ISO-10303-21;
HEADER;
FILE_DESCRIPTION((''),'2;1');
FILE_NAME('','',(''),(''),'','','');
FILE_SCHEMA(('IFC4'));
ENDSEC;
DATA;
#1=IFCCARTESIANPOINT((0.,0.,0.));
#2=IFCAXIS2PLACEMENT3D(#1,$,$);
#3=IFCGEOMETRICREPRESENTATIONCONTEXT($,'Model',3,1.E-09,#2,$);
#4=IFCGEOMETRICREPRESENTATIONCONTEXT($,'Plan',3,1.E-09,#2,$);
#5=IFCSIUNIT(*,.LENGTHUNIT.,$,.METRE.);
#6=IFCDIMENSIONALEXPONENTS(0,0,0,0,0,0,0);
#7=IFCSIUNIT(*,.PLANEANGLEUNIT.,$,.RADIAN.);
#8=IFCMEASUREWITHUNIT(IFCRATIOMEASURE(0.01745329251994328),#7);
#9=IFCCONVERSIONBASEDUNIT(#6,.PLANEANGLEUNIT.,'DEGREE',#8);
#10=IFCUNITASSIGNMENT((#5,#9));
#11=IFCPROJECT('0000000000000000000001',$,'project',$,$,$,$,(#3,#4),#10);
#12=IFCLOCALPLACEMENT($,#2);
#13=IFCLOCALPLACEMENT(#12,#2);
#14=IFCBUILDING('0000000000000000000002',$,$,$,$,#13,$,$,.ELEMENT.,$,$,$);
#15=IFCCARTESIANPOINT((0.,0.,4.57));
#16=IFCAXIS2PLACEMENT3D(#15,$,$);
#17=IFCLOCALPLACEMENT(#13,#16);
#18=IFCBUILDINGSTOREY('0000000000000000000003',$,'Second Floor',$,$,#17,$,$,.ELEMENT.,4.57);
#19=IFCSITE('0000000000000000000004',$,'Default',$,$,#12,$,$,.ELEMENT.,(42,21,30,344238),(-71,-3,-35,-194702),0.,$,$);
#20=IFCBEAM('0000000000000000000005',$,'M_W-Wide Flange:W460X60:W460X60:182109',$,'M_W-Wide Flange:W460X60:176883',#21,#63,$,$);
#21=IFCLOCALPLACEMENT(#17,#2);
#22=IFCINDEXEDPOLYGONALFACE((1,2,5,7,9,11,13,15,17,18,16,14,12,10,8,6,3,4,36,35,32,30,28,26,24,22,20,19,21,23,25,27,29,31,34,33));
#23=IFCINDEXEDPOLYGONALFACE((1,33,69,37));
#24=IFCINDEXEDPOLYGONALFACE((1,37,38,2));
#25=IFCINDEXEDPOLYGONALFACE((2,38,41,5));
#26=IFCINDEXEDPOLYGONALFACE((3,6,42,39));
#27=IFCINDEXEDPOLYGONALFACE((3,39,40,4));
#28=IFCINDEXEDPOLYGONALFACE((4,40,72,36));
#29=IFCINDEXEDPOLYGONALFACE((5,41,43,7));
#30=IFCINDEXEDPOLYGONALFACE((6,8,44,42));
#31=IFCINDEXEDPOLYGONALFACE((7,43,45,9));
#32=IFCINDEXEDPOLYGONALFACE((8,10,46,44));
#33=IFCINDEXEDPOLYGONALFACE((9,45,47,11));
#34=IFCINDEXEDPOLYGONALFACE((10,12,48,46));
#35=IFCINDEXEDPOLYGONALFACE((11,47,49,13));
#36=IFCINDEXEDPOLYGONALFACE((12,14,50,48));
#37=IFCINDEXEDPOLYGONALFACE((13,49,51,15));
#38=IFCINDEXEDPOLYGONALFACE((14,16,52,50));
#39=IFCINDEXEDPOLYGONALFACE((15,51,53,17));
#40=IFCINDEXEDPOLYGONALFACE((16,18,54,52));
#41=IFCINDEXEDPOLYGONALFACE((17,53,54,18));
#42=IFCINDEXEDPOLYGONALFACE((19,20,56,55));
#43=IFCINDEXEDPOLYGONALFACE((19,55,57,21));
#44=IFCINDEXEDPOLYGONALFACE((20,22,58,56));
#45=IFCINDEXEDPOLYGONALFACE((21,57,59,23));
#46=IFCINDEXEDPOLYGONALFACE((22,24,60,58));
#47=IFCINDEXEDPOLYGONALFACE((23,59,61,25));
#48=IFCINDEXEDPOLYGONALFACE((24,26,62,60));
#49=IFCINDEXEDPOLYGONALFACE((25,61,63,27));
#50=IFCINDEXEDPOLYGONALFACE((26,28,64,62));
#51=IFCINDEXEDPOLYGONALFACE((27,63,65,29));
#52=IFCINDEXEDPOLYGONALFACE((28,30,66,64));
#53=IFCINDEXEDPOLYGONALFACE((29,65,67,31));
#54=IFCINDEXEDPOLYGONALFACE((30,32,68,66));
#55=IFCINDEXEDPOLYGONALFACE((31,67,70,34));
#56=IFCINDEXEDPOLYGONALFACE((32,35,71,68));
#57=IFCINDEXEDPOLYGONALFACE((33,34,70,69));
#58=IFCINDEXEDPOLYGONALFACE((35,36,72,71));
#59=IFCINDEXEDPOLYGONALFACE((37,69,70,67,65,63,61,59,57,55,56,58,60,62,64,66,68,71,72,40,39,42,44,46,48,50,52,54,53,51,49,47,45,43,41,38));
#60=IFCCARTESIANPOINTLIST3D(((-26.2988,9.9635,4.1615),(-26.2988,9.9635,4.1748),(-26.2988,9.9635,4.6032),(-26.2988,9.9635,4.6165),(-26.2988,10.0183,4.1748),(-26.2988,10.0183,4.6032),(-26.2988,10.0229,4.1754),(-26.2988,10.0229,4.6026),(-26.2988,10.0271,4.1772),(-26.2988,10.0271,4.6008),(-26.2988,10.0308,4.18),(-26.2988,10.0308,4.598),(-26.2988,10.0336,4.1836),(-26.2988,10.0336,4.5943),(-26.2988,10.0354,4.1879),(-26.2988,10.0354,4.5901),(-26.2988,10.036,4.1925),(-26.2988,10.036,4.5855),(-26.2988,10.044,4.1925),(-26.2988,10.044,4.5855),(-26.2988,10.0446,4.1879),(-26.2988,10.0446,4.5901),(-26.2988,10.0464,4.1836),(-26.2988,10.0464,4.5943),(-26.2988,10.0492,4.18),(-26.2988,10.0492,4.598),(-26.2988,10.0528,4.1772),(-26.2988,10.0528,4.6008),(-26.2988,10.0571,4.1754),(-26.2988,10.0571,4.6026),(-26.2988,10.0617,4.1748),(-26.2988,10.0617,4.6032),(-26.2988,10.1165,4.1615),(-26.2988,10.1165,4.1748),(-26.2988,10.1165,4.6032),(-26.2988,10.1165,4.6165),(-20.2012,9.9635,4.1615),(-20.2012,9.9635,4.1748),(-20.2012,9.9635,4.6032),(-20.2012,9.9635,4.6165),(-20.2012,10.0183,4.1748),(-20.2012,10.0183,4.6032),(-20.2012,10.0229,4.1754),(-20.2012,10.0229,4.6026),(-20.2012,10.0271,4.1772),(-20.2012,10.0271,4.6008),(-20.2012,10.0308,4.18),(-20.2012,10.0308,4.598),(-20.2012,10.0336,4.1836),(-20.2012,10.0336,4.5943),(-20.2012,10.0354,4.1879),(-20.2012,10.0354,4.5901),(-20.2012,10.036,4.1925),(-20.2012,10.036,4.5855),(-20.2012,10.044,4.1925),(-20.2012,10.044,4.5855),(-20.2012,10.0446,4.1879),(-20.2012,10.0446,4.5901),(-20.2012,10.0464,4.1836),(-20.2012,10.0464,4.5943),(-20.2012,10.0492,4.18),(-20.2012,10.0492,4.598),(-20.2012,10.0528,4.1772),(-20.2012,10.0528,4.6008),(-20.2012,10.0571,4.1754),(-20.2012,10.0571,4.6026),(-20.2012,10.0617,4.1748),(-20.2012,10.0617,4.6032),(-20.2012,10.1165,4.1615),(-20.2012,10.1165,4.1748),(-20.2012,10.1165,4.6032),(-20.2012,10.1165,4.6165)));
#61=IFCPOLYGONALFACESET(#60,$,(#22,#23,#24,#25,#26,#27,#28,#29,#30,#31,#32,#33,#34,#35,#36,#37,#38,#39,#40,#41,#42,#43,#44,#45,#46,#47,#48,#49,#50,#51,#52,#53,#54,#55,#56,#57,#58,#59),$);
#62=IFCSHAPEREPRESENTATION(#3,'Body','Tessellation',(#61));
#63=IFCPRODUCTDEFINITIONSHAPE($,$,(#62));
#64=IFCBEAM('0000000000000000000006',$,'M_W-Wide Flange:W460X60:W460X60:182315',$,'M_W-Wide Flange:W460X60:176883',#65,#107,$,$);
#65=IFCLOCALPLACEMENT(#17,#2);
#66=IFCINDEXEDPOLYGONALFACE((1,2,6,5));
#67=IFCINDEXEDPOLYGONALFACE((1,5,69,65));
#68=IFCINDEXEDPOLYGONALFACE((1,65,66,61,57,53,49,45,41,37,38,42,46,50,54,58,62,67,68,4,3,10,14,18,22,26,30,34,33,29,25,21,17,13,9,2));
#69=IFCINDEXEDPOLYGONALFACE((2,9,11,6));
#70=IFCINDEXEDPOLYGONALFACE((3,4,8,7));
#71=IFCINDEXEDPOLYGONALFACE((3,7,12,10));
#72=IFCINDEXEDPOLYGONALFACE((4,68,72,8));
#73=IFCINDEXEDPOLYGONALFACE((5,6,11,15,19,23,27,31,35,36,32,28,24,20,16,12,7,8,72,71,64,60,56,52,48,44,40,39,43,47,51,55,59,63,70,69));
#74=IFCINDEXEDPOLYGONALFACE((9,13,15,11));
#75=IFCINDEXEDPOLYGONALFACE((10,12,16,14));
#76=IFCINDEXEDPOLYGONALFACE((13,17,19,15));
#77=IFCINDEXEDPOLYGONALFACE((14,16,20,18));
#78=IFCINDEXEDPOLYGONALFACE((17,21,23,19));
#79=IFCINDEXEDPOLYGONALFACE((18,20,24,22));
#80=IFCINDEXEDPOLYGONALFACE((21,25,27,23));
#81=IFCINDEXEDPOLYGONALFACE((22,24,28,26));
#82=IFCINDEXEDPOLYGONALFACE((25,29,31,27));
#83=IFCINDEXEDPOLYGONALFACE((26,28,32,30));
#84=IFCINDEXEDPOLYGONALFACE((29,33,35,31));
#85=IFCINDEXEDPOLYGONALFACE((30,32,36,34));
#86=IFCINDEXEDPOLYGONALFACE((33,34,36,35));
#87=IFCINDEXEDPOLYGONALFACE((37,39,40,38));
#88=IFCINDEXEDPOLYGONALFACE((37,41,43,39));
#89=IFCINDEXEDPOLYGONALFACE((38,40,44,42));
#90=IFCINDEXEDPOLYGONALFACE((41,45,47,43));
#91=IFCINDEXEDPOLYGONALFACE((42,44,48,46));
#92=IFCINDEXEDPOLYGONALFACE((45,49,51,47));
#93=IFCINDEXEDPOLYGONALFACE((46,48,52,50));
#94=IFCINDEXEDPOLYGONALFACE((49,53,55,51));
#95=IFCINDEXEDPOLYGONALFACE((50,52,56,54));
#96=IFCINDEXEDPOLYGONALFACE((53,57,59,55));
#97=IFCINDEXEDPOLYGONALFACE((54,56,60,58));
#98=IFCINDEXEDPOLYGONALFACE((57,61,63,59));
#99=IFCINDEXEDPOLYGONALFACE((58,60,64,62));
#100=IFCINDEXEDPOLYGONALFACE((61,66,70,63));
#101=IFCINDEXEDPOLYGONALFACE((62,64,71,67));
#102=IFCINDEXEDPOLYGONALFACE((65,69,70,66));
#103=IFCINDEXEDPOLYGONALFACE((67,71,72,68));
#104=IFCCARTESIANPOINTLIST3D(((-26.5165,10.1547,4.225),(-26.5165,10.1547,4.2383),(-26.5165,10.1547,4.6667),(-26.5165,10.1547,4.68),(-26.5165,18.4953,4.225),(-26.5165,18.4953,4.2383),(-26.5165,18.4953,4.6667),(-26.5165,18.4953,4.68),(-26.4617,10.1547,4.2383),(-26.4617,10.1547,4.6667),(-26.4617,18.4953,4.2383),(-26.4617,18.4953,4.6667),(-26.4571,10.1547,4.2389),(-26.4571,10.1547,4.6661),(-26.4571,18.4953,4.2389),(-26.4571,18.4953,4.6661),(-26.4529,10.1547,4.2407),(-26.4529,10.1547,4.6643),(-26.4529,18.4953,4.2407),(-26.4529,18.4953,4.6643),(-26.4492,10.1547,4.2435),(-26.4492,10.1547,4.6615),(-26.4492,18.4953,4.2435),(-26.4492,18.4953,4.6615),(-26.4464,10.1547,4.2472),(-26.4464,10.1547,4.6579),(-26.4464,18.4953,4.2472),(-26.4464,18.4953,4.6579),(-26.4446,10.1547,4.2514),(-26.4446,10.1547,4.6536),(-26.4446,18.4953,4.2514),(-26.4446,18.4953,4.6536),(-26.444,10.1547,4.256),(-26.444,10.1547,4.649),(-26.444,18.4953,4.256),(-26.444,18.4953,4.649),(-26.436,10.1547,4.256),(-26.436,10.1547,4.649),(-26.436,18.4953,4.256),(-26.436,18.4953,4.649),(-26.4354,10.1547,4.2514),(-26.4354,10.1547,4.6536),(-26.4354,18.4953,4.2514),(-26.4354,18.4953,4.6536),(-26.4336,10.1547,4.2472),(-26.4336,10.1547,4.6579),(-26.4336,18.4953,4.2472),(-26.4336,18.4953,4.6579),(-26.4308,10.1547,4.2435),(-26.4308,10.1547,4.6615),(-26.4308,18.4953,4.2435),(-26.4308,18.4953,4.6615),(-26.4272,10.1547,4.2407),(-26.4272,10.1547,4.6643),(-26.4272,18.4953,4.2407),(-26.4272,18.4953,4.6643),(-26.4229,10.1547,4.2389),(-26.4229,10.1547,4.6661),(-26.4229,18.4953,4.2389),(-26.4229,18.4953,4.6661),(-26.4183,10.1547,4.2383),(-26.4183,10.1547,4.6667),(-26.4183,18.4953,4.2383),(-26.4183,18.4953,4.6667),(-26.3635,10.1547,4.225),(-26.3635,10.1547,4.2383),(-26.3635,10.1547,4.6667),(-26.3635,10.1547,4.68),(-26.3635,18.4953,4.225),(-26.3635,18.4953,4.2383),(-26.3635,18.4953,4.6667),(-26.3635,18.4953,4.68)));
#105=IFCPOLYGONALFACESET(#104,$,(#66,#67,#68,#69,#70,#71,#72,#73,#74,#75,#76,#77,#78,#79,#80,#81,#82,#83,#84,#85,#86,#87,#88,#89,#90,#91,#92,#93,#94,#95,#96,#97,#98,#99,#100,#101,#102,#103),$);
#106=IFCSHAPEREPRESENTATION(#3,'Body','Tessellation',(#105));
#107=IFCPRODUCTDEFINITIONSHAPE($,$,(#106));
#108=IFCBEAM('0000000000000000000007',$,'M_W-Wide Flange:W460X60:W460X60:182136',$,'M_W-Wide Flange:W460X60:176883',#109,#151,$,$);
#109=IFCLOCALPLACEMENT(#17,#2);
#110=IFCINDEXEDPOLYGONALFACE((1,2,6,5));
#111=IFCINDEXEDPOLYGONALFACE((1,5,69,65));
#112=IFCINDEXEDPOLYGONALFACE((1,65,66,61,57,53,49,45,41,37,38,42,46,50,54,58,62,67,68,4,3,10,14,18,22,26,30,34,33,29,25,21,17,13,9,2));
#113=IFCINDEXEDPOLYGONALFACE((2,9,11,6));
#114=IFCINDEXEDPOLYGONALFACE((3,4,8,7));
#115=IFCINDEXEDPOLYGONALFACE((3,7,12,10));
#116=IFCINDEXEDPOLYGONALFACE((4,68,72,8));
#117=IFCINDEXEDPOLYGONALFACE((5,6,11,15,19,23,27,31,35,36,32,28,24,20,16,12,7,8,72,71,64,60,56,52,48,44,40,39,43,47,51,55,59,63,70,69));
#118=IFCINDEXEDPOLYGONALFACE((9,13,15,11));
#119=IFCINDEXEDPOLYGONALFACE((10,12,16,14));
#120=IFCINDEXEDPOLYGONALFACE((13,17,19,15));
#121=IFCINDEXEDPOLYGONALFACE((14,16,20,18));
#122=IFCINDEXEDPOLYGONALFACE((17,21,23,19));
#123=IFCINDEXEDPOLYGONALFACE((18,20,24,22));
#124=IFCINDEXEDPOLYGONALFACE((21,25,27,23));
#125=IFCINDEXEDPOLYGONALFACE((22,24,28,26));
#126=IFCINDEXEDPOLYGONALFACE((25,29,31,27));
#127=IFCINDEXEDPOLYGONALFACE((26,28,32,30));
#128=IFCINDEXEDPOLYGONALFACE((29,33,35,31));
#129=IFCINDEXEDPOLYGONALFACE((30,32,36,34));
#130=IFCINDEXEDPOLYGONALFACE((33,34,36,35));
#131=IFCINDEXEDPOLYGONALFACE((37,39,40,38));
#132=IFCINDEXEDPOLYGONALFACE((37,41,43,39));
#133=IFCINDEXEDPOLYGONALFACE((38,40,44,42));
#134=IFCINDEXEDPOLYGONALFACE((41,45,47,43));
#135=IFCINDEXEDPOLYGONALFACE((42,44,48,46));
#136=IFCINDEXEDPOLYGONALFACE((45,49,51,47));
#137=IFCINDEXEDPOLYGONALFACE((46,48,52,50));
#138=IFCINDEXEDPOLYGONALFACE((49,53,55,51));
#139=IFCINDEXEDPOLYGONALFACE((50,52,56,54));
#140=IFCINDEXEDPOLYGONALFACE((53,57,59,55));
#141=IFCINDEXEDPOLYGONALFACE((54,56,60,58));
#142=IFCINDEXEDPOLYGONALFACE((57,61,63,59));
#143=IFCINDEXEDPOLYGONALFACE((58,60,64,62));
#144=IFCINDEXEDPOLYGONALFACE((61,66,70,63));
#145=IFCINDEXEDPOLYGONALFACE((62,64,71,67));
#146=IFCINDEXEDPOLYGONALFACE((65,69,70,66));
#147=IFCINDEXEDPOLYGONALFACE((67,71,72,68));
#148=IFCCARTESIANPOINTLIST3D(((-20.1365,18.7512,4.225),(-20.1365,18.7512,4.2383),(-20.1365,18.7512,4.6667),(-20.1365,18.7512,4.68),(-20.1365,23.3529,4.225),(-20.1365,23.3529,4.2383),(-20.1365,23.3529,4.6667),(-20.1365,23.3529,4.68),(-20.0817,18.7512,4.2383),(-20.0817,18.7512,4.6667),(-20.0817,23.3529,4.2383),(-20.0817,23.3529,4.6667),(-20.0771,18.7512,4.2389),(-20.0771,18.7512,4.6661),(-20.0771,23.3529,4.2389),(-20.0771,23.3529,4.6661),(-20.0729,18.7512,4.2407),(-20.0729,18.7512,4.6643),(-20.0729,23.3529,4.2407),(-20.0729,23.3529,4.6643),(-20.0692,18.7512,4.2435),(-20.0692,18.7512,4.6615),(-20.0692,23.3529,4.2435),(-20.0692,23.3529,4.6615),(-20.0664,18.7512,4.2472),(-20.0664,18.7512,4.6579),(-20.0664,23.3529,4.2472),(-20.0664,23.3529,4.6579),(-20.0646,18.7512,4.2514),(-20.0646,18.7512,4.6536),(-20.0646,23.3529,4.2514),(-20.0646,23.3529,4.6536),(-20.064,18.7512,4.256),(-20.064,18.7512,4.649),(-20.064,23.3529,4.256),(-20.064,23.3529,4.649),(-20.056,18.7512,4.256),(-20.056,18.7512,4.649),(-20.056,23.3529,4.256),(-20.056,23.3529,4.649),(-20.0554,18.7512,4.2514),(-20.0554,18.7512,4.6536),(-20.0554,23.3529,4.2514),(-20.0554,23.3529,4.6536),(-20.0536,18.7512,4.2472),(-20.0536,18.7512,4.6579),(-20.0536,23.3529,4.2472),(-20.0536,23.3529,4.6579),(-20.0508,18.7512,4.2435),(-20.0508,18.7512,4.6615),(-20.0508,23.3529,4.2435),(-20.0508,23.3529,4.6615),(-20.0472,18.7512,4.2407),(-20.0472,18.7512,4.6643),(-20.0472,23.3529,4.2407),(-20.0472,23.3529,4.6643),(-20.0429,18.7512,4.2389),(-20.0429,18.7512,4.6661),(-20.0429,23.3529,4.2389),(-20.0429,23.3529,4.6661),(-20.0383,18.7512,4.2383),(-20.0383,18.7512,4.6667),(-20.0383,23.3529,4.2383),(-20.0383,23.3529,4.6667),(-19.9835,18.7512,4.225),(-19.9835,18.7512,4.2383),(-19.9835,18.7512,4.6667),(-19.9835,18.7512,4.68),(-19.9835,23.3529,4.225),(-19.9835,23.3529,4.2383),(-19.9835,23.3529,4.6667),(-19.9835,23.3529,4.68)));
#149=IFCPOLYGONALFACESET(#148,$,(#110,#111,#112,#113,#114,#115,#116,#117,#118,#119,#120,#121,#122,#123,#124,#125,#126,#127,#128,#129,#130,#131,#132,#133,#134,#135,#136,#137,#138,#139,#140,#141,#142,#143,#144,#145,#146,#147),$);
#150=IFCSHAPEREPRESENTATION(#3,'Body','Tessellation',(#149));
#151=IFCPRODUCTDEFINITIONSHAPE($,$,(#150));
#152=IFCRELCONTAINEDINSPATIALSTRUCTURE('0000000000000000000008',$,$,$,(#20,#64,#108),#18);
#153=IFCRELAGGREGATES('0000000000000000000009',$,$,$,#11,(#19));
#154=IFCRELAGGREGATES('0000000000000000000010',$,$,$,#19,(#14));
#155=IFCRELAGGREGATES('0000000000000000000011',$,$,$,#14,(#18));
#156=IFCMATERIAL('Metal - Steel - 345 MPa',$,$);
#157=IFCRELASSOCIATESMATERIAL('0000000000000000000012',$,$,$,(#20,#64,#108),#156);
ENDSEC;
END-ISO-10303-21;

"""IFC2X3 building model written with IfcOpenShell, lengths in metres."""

from ifc_helpers import new_model, entity, si_unit, converted_unit, frame, frame_2d, origin, place, context, project, spatial, polyline, circle_curve, parameter, trimmed, segment, composite_curve, outline, extrude, material, element, save


model = new_model("IFC2X3")

# Units and contexts
model_context = context("Model", 3, precision=1e-09, world=origin())
plan_context = context("Plan", 3, precision=1e-09, world=origin())
ifc_project = project(units=[si_unit("LENGTHUNIT", "METRE"), converted_unit("PLANEANGLEUNIT", "DEGREE", entity("IfcRatioMeasure", 0.01745329251994328), si_unit("PLANEANGLEUNIT", "RADIAN"), dimensions=[0, 0, 0, 0, 0, 0, 0])], contexts=[model_context, plan_context])

# Site, building, storey
site_placement = place(None, origin())
site = spatial("IfcSite", under=ifc_project, at=site_placement, Name="Default", CompositionType="ELEMENT", RefLatitude=(42, 21, 30, 344238), RefLongitude=(-71, -3, -35, -194702), RefElevation=0.0)
building_placement = place(site_placement, origin())
building = spatial("IfcBuilding", under=site, at=building_placement, CompositionType="ELEMENT")
storey_placement = place(building_placement, frame((0.0, 0.0, 4.57)))
storey = spatial("IfcBuildingStorey", under=building, at=storey_placement, Name="Second Floor", CompositionType="ELEMENT", Elevation=4.57)

# Shared definitions
ifc_material = material(Name="Metal - Steel - 345 MPa")

# Beams
beam_1_placement = place(storey_placement, frame((-26.437, 10.04, 4.6165), z_axis=(0.0, 0.0, 1.0), x_axis=(0.0, -1.0, 0.0)))
element("IfcBeam", 1, at=beam_1_placement, inside=storey, material=ifc_material, Name="M_W-Wide Flange:W460X60:W460X60:182109", ObjectType="M_W-Wide Flange:W460X60:176883", context=model_context, shape_type="SweptSolid", body=[
    extrude(outline(composite_curve([segment(polyline([(-0.0765, -0.2142), (-0.0765, -0.2275)]), True, "CONTINUOUS"), segment(polyline([(-0.0765, -0.2275), (0.0765, -0.2275)]), True, "CONTINUOUS"), segment(polyline([(0.0765, -0.2275), (0.0765, -0.2142)]), True, "CONTINUOUS"), segment(polyline([(0.0765, -0.2142), (0.0217, -0.2142)]), True, "CONTINUOUS"), segment(trimmed(circle_curve(frame_2d((0.0217, -0.1965), x_axis=(0.0, -1.0)), 0.0177), [parameter(270.0)], [parameter(360.0)], True, "PARAMETER"), False, "CONTINUOUS"), segment(polyline([(0.004, -0.1965), (0.004, 0.1965)]), True, "CONTINUOUS"), segment(trimmed(circle_curve(frame_2d((0.0217, 0.1965), x_axis=(-1.0, 0.0)), 0.0177), [parameter(270.0)], [parameter(360.0)], True, "PARAMETER"), False, "CONTINUOUS"), segment(polyline([(0.0217, 0.2142), (0.0765, 0.2142)]), True, "CONTINUOUS"), segment(polyline([(0.0765, 0.2142), (0.0765, 0.2275)]), True, "CONTINUOUS"), segment(polyline([(0.0765, 0.2275), (-0.0765, 0.2275)]), True, "CONTINUOUS"), segment(polyline([(-0.0765, 0.2275), (-0.0765, 0.2142)]), True, "CONTINUOUS"), segment(polyline([(-0.0765, 0.2142), (-0.0217, 0.2142)]), True, "CONTINUOUS"), segment(trimmed(circle_curve(frame_2d((-0.0217, 0.1965), x_axis=(0.0, 1.0)), 0.0177), [parameter(270.0)], [parameter(360.0)], True, "PARAMETER"), False, "CONTINUOUS"), segment(polyline([(-0.004, 0.1965), (-0.004, -0.1965)]), True, "CONTINUOUS"), segment(trimmed(circle_curve(frame_2d((-0.0217, -0.1965), x_axis=(1.0, 0.0)), 0.0177), [parameter(270.0)], [parameter(0.0)], True, "PARAMETER"), False, "CONTINUOUS"), segment(polyline([(-0.0217, -0.2142), (-0.0765, -0.2142)]), True, "CONTINUOUS")], self_intersect=False)), frame((0.0, 0.1382, -0.2275), z_axis=(0.0, -1.0, 0.0), x_axis=(1.0, 0.0, 0.0)), (0.0, 0.0, -1.0), 6.0976),
])
beam_2_placement = place(storey_placement, frame((-26.44, 18.6078, 4.68), z_axis=(0.0, 0.0, 1.0), x_axis=(-1.0, 0.0, 0.0)))
element("IfcBeam", 2, at=beam_2_placement, inside=storey, material=ifc_material, Name="M_W-Wide Flange:W460X60:W460X60:182315", ObjectType="M_W-Wide Flange:W460X60:176883", context=model_context, shape_type="SweptSolid", body=[
    extrude(outline(composite_curve([segment(polyline([(0.2142, -0.0765), (0.2275, -0.0765)]), True, "CONTINUOUS"), segment(polyline([(0.2275, -0.0765), (0.2275, 0.0765)]), True, "CONTINUOUS"), segment(polyline([(0.2275, 0.0765), (0.2142, 0.0765)]), True, "CONTINUOUS"), segment(polyline([(0.2142, 0.0765), (0.2142, 0.0217)]), True, "CONTINUOUS"), segment(trimmed(circle_curve(frame_2d((0.1965, 0.0217), x_axis=(1.0, 0.0)), 0.0177), [parameter(270.0)], [parameter(360.0)], True, "PARAMETER"), False, "CONTINUOUS"), segment(polyline([(0.1965, 0.004), (-0.1965, 0.004)]), True, "CONTINUOUS"), segment(trimmed(circle_curve(frame_2d((-0.1965, 0.0217), x_axis=(0.0, -1.0)), 0.0177), [parameter(270.0)], [parameter(360.0)], True, "PARAMETER"), False, "CONTINUOUS"), segment(polyline([(-0.2142, 0.0217), (-0.2142, 0.0765)]), True, "CONTINUOUS"), segment(polyline([(-0.2142, 0.0765), (-0.2275, 0.0765)]), True, "CONTINUOUS"), segment(polyline([(-0.2275, 0.0765), (-0.2275, -0.0765)]), True, "CONTINUOUS"), segment(polyline([(-0.2275, -0.0765), (-0.2142, -0.0765)]), True, "CONTINUOUS"), segment(polyline([(-0.2142, -0.0765), (-0.2142, -0.0217)]), True, "CONTINUOUS"), segment(trimmed(circle_curve(frame_2d((-0.1965, -0.0217), x_axis=(-1.0, 0.0)), 0.0177), [parameter(270.0)], [parameter(360.0)], True, "PARAMETER"), False, "CONTINUOUS"), segment(polyline([(-0.1965, -0.004), (0.1965, -0.004)]), True, "CONTINUOUS"), segment(trimmed(circle_curve(frame_2d((0.1965, -0.0217), x_axis=(0.0, 1.0)), 0.0177), [parameter(270.0)], [parameter(0.0)], True, "PARAMETER"), False, "CONTINUOUS"), segment(polyline([(0.2142, -0.0217), (0.2142, -0.0765)]), True, "CONTINUOUS")], self_intersect=False)), frame((0.0, 8.4531, -0.2275), z_axis=(0.0, -1.0, 0.0), x_axis=(0.0, 0.0, -1.0)), (0.0, 0.0, 1.0), 8.3406),
])
beam_3_placement = place(storey_placement, frame((-20.06, 18.6139, 4.68)))
element("IfcBeam", 3, at=beam_3_placement, inside=storey, material=ifc_material, Name="M_W-Wide Flange:W460X60:W460X60:182136", ObjectType="M_W-Wide Flange:W460X60:176883", context=model_context, shape_type="SweptSolid", body=[
    extrude(outline(composite_curve([segment(polyline([(-0.0765, -0.2142), (-0.0765, -0.2275)]), True, "CONTINUOUS"), segment(polyline([(-0.0765, -0.2275), (0.0765, -0.2275)]), True, "CONTINUOUS"), segment(polyline([(0.0765, -0.2275), (0.0765, -0.2142)]), True, "CONTINUOUS"), segment(polyline([(0.0765, -0.2142), (0.0217, -0.2142)]), True, "CONTINUOUS"), segment(trimmed(circle_curve(frame_2d((0.0217, -0.1965), x_axis=(0.0, -1.0)), 0.0177), [parameter(270.0)], [parameter(360.0)], True, "PARAMETER"), False, "CONTINUOUS"), segment(polyline([(0.004, -0.1965), (0.004, 0.1965)]), True, "CONTINUOUS"), segment(trimmed(circle_curve(frame_2d((0.0217, 0.1965), x_axis=(-1.0, 0.0)), 0.0177), [parameter(270.0)], [parameter(360.0)], True, "PARAMETER"), False, "CONTINUOUS"), segment(polyline([(0.0217, 0.2142), (0.0765, 0.2142)]), True, "CONTINUOUS"), segment(polyline([(0.0765, 0.2142), (0.0765, 0.2275)]), True, "CONTINUOUS"), segment(polyline([(0.0765, 0.2275), (-0.0765, 0.2275)]), True, "CONTINUOUS"), segment(polyline([(-0.0765, 0.2275), (-0.0765, 0.2142)]), True, "CONTINUOUS"), segment(polyline([(-0.0765, 0.2142), (-0.0217, 0.2142)]), True, "CONTINUOUS"), segment(trimmed(circle_curve(frame_2d((-0.0217, 0.1965), x_axis=(0.0, 1.0)), 0.0177), [parameter(270.0)], [parameter(360.0)], True, "PARAMETER"), False, "CONTINUOUS"), segment(polyline([(-0.004, 0.1965), (-0.004, -0.1965)]), True, "CONTINUOUS"), segment(trimmed(circle_curve(frame_2d((-0.0217, -0.1965), x_axis=(1.0, 0.0)), 0.0177), [parameter(270.0)], [parameter(0.0)], True, "PARAMETER"), False, "CONTINUOUS"), segment(polyline([(-0.0217, -0.2142), (-0.0765, -0.2142)]), True, "CONTINUOUS")], self_intersect=False)), frame((0.0, 0.1373, -0.2275), z_axis=(0.0, -1.0, 0.0), x_axis=(1.0, 0.0, 0.0)), (0.0, 0.0, -1.0), 4.6017),
])

save(model, "model.ifc")
